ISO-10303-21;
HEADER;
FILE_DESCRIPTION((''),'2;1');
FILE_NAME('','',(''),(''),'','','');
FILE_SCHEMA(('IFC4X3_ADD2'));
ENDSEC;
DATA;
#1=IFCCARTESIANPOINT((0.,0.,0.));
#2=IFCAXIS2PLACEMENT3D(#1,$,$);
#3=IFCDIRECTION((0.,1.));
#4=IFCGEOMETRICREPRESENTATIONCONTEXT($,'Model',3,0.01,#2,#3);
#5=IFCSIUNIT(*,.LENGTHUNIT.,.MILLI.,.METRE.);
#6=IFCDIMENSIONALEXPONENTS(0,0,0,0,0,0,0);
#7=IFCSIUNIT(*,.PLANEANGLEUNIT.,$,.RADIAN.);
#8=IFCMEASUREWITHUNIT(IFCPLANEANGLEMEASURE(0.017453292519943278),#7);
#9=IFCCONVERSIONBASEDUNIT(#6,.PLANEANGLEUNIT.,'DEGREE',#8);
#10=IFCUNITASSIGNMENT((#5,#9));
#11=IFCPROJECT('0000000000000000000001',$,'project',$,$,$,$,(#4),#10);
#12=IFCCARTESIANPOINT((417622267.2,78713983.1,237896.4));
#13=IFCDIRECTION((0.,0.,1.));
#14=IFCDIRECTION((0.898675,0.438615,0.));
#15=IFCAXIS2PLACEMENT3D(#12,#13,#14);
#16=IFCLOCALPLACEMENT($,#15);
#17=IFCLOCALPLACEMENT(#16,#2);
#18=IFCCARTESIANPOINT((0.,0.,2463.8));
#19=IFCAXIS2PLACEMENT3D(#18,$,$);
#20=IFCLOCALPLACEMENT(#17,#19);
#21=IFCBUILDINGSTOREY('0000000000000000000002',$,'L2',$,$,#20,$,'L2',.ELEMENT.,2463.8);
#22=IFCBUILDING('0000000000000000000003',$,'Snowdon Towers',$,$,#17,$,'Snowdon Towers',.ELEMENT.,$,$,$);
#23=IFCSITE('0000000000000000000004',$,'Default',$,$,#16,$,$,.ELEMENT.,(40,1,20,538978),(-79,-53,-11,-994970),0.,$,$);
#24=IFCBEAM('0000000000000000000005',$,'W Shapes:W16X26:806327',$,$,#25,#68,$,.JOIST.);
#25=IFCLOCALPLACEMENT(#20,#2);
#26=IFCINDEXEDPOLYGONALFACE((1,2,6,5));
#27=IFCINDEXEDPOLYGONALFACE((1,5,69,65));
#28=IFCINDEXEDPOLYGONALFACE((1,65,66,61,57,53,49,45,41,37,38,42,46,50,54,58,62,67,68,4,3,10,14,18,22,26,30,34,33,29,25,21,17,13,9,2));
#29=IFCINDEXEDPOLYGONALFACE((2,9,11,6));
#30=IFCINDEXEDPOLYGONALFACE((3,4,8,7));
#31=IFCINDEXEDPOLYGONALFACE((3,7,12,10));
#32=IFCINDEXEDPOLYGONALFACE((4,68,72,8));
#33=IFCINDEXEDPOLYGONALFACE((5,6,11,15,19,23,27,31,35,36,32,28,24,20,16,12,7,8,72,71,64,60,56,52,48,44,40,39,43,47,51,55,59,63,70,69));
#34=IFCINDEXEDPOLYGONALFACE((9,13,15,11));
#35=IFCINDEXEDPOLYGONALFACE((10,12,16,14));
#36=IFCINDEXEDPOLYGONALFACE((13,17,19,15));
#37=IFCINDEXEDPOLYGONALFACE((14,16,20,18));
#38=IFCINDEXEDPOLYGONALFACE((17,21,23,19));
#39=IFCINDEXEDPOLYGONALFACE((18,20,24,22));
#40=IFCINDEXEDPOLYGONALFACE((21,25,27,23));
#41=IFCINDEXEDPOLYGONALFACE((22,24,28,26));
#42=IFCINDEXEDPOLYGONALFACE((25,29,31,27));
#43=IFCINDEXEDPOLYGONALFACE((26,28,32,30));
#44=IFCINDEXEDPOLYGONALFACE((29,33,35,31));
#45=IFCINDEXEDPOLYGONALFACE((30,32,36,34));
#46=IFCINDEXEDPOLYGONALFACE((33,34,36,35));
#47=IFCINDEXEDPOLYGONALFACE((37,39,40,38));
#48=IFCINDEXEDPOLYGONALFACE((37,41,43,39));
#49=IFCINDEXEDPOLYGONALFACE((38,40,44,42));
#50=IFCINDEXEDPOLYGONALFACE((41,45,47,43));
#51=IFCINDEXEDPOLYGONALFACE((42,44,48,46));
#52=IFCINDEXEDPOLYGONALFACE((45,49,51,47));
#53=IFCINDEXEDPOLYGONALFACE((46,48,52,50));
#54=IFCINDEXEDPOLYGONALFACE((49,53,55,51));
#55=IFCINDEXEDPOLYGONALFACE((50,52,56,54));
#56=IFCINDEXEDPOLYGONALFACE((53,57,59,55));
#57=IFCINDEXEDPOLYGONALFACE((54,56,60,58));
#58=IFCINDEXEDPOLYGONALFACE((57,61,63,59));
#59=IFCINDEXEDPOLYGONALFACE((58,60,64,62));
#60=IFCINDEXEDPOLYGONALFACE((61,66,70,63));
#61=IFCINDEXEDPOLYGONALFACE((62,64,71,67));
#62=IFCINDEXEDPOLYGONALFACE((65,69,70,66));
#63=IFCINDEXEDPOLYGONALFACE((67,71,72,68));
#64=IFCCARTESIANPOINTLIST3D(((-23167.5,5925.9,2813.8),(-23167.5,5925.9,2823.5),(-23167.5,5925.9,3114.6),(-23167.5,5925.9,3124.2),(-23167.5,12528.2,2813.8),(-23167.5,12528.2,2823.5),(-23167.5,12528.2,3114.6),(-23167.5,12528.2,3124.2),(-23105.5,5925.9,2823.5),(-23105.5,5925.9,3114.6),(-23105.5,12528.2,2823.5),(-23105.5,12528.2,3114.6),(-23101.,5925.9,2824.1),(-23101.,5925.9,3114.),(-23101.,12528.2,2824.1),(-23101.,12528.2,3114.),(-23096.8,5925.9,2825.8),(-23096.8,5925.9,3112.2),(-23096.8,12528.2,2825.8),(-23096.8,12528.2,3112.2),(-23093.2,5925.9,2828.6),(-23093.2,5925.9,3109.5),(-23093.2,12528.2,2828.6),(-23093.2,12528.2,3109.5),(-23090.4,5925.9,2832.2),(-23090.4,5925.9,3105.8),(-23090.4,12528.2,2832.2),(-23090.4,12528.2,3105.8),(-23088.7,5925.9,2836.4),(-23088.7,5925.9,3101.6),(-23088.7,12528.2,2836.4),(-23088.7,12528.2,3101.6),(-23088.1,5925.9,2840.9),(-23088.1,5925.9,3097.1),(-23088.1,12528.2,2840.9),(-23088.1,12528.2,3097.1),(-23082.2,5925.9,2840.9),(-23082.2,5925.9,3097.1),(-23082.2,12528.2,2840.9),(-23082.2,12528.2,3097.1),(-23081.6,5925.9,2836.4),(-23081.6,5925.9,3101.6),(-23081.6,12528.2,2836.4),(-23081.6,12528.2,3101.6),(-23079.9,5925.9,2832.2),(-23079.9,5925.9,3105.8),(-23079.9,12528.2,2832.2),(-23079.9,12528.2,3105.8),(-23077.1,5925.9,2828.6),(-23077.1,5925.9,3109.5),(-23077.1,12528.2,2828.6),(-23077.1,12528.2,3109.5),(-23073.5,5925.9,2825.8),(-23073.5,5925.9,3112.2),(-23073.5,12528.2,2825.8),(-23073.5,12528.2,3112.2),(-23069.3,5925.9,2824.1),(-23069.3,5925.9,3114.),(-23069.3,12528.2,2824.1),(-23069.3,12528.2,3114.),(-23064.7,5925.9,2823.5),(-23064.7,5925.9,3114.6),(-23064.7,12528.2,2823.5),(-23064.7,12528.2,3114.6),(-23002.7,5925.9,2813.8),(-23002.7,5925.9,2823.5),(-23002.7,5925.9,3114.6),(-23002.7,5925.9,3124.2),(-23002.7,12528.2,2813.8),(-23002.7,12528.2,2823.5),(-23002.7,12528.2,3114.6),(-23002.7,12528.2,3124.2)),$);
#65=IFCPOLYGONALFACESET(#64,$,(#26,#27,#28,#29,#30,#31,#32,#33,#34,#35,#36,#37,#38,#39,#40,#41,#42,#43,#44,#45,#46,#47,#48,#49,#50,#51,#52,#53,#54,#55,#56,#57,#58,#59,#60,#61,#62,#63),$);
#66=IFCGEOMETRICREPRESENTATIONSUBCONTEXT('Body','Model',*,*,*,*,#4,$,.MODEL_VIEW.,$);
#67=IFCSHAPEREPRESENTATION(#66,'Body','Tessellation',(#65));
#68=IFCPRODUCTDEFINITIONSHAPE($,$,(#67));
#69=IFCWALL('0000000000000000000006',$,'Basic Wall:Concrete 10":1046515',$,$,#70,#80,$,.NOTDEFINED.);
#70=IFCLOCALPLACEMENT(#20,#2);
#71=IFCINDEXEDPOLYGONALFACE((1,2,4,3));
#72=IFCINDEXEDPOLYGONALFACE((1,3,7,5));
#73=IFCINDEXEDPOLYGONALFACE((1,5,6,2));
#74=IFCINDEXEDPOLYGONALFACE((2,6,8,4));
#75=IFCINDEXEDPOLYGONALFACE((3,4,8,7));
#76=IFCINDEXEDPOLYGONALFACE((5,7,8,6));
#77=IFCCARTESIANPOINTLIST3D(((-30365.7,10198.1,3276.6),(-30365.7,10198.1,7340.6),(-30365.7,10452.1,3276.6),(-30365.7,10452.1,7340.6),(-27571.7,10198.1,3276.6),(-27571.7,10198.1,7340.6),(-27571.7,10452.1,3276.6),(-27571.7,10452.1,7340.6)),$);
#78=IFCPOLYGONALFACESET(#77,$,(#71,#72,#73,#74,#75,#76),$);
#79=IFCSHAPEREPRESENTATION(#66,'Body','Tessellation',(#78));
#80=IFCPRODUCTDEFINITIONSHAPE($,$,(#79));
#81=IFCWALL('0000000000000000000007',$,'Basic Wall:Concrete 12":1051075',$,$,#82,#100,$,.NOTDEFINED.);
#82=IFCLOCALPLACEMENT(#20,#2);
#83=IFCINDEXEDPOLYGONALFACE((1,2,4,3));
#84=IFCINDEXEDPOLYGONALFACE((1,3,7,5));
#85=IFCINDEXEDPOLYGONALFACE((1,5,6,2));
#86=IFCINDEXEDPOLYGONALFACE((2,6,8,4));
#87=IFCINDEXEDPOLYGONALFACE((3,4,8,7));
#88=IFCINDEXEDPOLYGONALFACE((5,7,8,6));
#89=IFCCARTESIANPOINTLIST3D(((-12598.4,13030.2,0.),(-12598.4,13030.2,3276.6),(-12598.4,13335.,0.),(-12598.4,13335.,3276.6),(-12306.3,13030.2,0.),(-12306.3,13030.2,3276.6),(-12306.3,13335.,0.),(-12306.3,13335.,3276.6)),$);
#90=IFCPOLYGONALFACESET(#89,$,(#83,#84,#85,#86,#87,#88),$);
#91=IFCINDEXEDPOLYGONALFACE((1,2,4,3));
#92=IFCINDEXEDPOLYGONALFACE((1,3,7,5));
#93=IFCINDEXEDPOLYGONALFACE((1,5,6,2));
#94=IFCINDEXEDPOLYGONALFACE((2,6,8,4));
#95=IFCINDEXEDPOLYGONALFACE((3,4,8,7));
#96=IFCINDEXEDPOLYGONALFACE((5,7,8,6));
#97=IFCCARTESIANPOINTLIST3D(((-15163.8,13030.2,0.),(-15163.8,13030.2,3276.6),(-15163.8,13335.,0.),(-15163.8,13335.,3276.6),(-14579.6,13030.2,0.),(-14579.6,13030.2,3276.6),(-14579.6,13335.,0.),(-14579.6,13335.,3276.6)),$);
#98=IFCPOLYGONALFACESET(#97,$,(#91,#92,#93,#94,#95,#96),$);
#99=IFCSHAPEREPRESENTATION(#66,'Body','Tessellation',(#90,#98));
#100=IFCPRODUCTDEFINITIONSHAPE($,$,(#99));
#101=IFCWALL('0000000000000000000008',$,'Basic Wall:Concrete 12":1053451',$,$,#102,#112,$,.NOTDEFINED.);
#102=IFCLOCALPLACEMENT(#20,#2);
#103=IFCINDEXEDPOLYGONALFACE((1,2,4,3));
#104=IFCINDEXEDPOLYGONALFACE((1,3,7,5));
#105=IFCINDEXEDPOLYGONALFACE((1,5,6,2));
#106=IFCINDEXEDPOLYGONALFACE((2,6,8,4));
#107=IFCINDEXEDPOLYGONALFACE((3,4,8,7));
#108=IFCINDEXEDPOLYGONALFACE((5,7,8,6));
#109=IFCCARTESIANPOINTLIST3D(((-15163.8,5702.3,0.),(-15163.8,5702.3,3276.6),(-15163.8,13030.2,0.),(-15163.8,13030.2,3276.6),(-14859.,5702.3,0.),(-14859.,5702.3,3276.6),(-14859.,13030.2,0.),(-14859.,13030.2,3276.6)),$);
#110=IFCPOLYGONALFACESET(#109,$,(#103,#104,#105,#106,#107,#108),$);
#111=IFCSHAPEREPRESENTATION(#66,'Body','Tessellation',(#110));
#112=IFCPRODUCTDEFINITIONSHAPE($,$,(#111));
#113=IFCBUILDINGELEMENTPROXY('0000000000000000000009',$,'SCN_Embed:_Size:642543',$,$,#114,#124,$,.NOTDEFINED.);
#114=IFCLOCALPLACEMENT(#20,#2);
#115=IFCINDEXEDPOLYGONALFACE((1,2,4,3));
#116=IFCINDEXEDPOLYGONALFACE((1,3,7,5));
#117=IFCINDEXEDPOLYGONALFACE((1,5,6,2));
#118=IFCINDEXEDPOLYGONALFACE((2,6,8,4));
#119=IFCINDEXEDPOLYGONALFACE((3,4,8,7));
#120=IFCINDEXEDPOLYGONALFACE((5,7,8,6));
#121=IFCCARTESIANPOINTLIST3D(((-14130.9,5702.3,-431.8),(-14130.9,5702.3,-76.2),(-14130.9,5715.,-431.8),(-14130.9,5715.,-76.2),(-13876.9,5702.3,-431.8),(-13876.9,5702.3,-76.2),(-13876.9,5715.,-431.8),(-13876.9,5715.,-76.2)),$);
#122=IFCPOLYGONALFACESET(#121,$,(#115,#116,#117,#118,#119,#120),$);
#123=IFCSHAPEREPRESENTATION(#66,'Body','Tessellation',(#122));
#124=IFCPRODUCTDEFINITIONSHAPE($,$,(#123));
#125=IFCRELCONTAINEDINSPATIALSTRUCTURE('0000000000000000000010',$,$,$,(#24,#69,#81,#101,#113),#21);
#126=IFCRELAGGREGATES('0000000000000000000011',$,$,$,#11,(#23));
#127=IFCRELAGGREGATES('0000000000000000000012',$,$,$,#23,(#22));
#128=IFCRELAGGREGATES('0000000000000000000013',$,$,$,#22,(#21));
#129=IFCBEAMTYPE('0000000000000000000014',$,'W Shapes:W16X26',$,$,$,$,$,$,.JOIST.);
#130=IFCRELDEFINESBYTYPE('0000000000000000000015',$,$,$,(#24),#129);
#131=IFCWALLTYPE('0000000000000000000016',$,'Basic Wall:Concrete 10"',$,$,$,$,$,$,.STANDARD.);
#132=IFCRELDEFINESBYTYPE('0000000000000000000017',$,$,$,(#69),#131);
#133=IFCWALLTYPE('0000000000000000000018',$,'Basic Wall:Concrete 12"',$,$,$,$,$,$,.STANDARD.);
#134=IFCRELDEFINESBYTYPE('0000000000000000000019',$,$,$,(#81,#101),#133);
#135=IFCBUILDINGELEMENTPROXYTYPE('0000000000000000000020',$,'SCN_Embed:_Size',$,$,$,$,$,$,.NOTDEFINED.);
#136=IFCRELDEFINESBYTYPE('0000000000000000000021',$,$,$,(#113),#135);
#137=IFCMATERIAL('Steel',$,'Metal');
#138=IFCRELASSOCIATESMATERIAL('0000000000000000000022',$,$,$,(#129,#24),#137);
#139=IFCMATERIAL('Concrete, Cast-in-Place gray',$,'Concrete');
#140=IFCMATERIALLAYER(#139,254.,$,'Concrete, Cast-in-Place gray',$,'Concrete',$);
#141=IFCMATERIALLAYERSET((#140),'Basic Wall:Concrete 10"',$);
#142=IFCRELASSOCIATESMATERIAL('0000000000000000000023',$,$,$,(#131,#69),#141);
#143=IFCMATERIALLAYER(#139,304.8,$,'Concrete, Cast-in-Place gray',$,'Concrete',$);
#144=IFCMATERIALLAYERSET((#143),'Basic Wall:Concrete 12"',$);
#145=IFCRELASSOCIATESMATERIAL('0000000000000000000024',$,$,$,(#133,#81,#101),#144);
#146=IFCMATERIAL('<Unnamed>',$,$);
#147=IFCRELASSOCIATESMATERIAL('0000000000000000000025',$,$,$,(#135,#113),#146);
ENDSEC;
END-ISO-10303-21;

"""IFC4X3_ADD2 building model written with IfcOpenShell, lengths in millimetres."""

from ifc_helpers import new_model, entity, si_unit, converted_unit, direction, frame, frame_2d, origin, place, context, subcontext, project, spatial, polyline, circle_curve, parameter, trimmed, segment, composite_curve, rectangle, outline, extrude, source, transform, mapped, material, layer, layer_set, material_profile, profile_set, profile_usage, type_object, type_shapes, element, save


model = new_model("IFC4X3_ADD2")

# Units and contexts
model_context = context("Model", 3, precision=0.01, world=origin(), true_north=direction((0.0, 1.0)))
body_context = subcontext(model_context, "Body", "Model", "MODEL_VIEW")
ifc_project = project(units=[si_unit("LENGTHUNIT", "METRE", prefix="MILLI"), converted_unit("PLANEANGLEUNIT", "DEGREE", entity("IfcPlaneAngleMeasure", 0.017453292519943278), si_unit("PLANEANGLEUNIT", "RADIAN"), dimensions=[0, 0, 0, 0, 0, 0, 0])], contexts=[model_context])

# Site, building, storey
site_placement = place(None, frame((417622267.2, 78713983.1, 237896.4), z_axis=(0.0, 0.0, 1.0), x_axis=(0.898675, 0.438615, 0.0)))
site = spatial("IfcSite", under=ifc_project, at=site_placement, Name="Default", CompositionType="ELEMENT", RefLatitude=(40, 1, 20, 538978), RefLongitude=(-79, -53, -11, -994970), RefElevation=0.0)
building_placement = place(site_placement, origin())
building = spatial("IfcBuilding", under=site, at=building_placement, Name="Snowdon Towers", LongName="Snowdon Towers", CompositionType="ELEMENT")
storey_placement = place(building_placement, frame((0.0, 0.0, 2463.8)))
storey = spatial("IfcBuildingStorey", under=building, at=storey_placement, Name="L2", LongName="L2", CompositionType="ELEMENT", Elevation=2463.8)

# Beam
ifc_material_1 = material(Name="Steel", Category="Metal")
ifc_material_profile_1 = material_profile(ifc_material_1, outline(composite_curve([segment(polyline([(-82.4, -145.6), (-82.4, -155.2)]), True, "CONTINUOUS"), segment(polyline([(-82.4, -155.2), (82.4, -155.2)]), True, "CONTINUOUS"), segment(polyline([(82.4, -155.2), (82.4, -145.6)]), True, "CONTINUOUS"), segment(polyline([(82.4, -145.6), (20.4, -145.6)]), True, "CONTINUOUS"), segment(trimmed(circle_curve(frame_2d((20.4, -128.1), x_axis=(1.0, 0.0)), 17.5), [parameter(180.0)], [parameter(270.0)], True, "PARAMETER"), False, "CONTINUOUS"), segment(polyline([(2.9, -128.1), (2.9, 128.1)]), True, "CONTINUOUS"), segment(trimmed(circle_curve(frame_2d((20.4, 128.1), x_axis=(1.0, 0.0)), 17.5), [parameter(90.0)], [parameter(180.0)], True, "PARAMETER"), False, "CONTINUOUS"), segment(polyline([(20.4, 145.6), (82.4, 145.6)]), True, "CONTINUOUS"), segment(polyline([(82.4, 145.6), (82.4, 155.2)]), True, "CONTINUOUS"), segment(polyline([(82.4, 155.2), (-82.4, 155.2)]), True, "CONTINUOUS"), segment(polyline([(-82.4, 155.2), (-82.4, 145.6)]), True, "CONTINUOUS"), segment(polyline([(-82.4, 145.6), (-20.4, 145.6)]), True, "CONTINUOUS"), segment(trimmed(circle_curve(frame_2d((-20.4, 128.1), x_axis=(1.0, 0.0)), 17.5), [parameter(360.0)], [parameter(90.0)], True, "PARAMETER"), False, "CONTINUOUS"), segment(polyline([(-2.9, 128.1), (-2.9, -128.1)]), True, "CONTINUOUS"), segment(trimmed(circle_curve(frame_2d((-20.4, -128.1), x_axis=(1.0, 0.0)), 17.5), [parameter(270.0)], [parameter(360.0)], True, "PARAMETER"), False, "CONTINUOUS"), segment(polyline([(-20.4, -145.6), (-82.4, -145.6)]), True, "CONTINUOUS")], self_intersect=False)), Name="W16X26")
ifc_profile_set_1 = profile_set([ifc_material_profile_1], Name="W16X26")
ifc_profile_usage_1 = profile_usage(ifc_profile_set_1, cardinal=8)
beam_type_1 = type_object("IfcBeamType", Name="W Shapes:W16X26", PredefinedType="JOIST", material=ifc_profile_set_1)
shared_shape_1 = source(origin(), body_context, "Body", "SweptSolid", [
    extrude(outline(composite_curve([segment(polyline([(-82.4, -145.6), (-82.4, -155.2)]), True, "CONTINUOUS"), segment(polyline([(-82.4, -155.2), (82.4, -155.2)]), True, "CONTINUOUS"), segment(polyline([(82.4, -155.2), (82.4, -145.6)]), True, "CONTINUOUS"), segment(polyline([(82.4, -145.6), (20.4, -145.6)]), True, "CONTINUOUS"), segment(trimmed(circle_curve(frame_2d((20.4, -128.1), x_axis=(1.0, 0.0)), 17.5), [parameter(180.0)], [parameter(270.0)], True, "PARAMETER"), False, "CONTINUOUS"), segment(polyline([(2.9, -128.1), (2.9, 128.1)]), True, "CONTINUOUS"), segment(trimmed(circle_curve(frame_2d((20.4, 128.1), x_axis=(1.0, 0.0)), 17.5), [parameter(90.0)], [parameter(180.0)], True, "PARAMETER"), False, "CONTINUOUS"), segment(polyline([(20.4, 145.6), (82.4, 145.6)]), True, "CONTINUOUS"), segment(polyline([(82.4, 145.6), (82.4, 155.2)]), True, "CONTINUOUS"), segment(polyline([(82.4, 155.2), (-82.4, 155.2)]), True, "CONTINUOUS"), segment(polyline([(-82.4, 155.2), (-82.4, 145.6)]), True, "CONTINUOUS"), segment(polyline([(-82.4, 145.6), (-20.4, 145.6)]), True, "CONTINUOUS"), segment(trimmed(circle_curve(frame_2d((-20.4, 128.1), x_axis=(1.0, 0.0)), 17.5), [parameter(360.0)], [parameter(90.0)], True, "PARAMETER"), False, "CONTINUOUS"), segment(polyline([(-2.9, 128.1), (-2.9, -128.1)]), True, "CONTINUOUS"), segment(trimmed(circle_curve(frame_2d((-20.4, -128.1), x_axis=(1.0, 0.0)), 17.5), [parameter(270.0)], [parameter(360.0)], True, "PARAMETER"), False, "CONTINUOUS"), segment(polyline([(-20.4, -145.6), (-82.4, -145.6)]), True, "CONTINUOUS")], self_intersect=False)), frame((-3282.6, 0.0, 0.0), z_axis=(-1.0, 0.0, 0.0), x_axis=(0.0, -1.0, 0.0)), (0.0, 0.0, -1.0), 6602.3),
])
type_shapes(beam_type_1, [shared_shape_1])
beam_1_placement = place(storey_placement, frame((-23085.1, 9245.6, 2969.0), z_axis=(0.0, 0.0, 1.0), x_axis=(0.0, -1.0, 0.0)))
element("IfcBeam", 1, at=beam_1_placement, inside=storey, type_object=beam_type_1, material=ifc_profile_usage_1, Name="W Shapes:W16X26:806327", PredefinedType="JOIST", context=body_context, shape_type="MappedRepresentation", body=[
    mapped(shared_shape_1, transform((0.0, 0.0, 0.0), scale=1.0)),
])

# Walls
ifc_material_2 = material(Name="Concrete, Cast-in-Place gray", Category="Concrete")
ifc_layer_1 = layer(ifc_material_2, 254.0, Name="Concrete, Cast-in-Place gray", Category="Concrete")
ifc_layer_set_1 = layer_set([ifc_layer_1], Name="Basic Wall:Concrete 10\"")
wall_type_1 = type_object("IfcWallType", Name="Basic Wall:Concrete 10\"", PredefinedType="STANDARD", material=ifc_layer_set_1)
wall_1_placement = place(storey_placement, frame((-30365.7, 10325.1, 3276.6)))
element("IfcWall", 2, at=wall_1_placement, inside=storey, type_object=wall_type_1, material=ifc_layer_set_1, Name="Basic Wall:Concrete 10\":1046515", PredefinedType="NOTDEFINED", context=body_context, shape_type="SweptSolid", body=[
    extrude(rectangle(XDim=2794.0, YDim=254.0, at=frame_2d((1397.0, 0.0), x_axis=(-1.0, 0.0))), origin(), (0.0, 0.0, 1.0), 4064.0),
])
ifc_layer_2 = layer(ifc_material_2, 304.8, Name="Concrete, Cast-in-Place gray", Category="Concrete")
ifc_layer_set_2 = layer_set([ifc_layer_2], Name="Basic Wall:Concrete 12\"")
wall_type_2 = type_object("IfcWallType", Name="Basic Wall:Concrete 12\"", PredefinedType="STANDARD", material=ifc_layer_set_2)
wall_2_placement = place(storey_placement, frame((-12306.3, 13182.6, 0.0), z_axis=(0.0, 0.0, 1.0), x_axis=(-1.0, 0.0, 0.0)))
element("IfcWall", 3, at=wall_2_placement, inside=storey, type_object=wall_type_2, material=ifc_layer_set_2, Name="Basic Wall:Concrete 12\":1051075", PredefinedType="NOTDEFINED", context=body_context, shape_type="SweptSolid", body=[
    extrude(rectangle(XDim=304.8, YDim=292.1, at=frame_2d((0.0, 0.0), x_axis=(1.0, 0.0))), frame((146.1, 0.0, 0.0), z_axis=(0.0, 0.0, 1.0), x_axis=(0.0, 1.0, 0.0)), (0.0, 0.0, 1.0), 3276.6),
    extrude(rectangle(XDim=304.8, YDim=584.2, at=frame_2d((0.0, -4.2), x_axis=(1.0, 0.0))), frame((2561.2, 0.0, 0.0), z_axis=(0.0, 0.0, 1.0), x_axis=(0.0, 1.0, 0.0)), (0.0, 0.0, 1.0), 3276.6),
])
wall_3_placement = place(storey_placement, frame((-15011.4, 13030.2, 0.0), z_axis=(0.0, 0.0, 1.0), x_axis=(0.0, -1.0, 0.0)))
element("IfcWall", 4, at=wall_3_placement, inside=storey, type_object=wall_type_2, material=ifc_layer_set_2, Name="Basic Wall:Concrete 12\":1053451", PredefinedType="NOTDEFINED", context=body_context, shape_type="SweptSolid", body=[
    extrude(rectangle(XDim=7327.9, YDim=304.8, at=frame_2d((3664.0, 0.0), x_axis=(-1.0, 0.0))), origin(), (0.0, 0.0, 1.0), 3276.6),
])

# Building element proxy
ifc_material_3 = material(Name="<Unnamed>")
building_element_proxy_type_1 = type_object("IfcBuildingElementProxyType", Name="SCN_Embed:_Size", PredefinedType="NOTDEFINED", material=ifc_material_3)
shared_shape_2 = source(origin(), body_context, "Body", "SweptSolid", [
    extrude(rectangle(XDim=254.0, YDim=355.6, at=frame_2d((0.0, 0.0), x_axis=(1.0, 0.0))), frame((0.0, 0.0, -12.7), z_axis=(0.0, 0.0, 1.0), x_axis=(-1.0, 0.0, 0.0)), (0.0, 0.0, 1.0), 12.7),
])
type_shapes(building_element_proxy_type_1, [shared_shape_2])
proxy_placement = place(storey_placement, frame((-14003.9, 5702.3, -254.0), z_axis=(0.0, -1.0, 0.0), x_axis=(1.0, 0.0, 0.0)))
element("IfcBuildingElementProxy", 5, at=proxy_placement, inside=storey, type_object=building_element_proxy_type_1, material=ifc_material_3, Name="SCN_Embed:_Size:642543", PredefinedType="NOTDEFINED", context=body_context, shape_type="MappedRepresentation", body=[
    mapped(shared_shape_2, transform((0.0, 0.0, 0.0), scale=1.0)),
])

save(model, "model.ifc")
